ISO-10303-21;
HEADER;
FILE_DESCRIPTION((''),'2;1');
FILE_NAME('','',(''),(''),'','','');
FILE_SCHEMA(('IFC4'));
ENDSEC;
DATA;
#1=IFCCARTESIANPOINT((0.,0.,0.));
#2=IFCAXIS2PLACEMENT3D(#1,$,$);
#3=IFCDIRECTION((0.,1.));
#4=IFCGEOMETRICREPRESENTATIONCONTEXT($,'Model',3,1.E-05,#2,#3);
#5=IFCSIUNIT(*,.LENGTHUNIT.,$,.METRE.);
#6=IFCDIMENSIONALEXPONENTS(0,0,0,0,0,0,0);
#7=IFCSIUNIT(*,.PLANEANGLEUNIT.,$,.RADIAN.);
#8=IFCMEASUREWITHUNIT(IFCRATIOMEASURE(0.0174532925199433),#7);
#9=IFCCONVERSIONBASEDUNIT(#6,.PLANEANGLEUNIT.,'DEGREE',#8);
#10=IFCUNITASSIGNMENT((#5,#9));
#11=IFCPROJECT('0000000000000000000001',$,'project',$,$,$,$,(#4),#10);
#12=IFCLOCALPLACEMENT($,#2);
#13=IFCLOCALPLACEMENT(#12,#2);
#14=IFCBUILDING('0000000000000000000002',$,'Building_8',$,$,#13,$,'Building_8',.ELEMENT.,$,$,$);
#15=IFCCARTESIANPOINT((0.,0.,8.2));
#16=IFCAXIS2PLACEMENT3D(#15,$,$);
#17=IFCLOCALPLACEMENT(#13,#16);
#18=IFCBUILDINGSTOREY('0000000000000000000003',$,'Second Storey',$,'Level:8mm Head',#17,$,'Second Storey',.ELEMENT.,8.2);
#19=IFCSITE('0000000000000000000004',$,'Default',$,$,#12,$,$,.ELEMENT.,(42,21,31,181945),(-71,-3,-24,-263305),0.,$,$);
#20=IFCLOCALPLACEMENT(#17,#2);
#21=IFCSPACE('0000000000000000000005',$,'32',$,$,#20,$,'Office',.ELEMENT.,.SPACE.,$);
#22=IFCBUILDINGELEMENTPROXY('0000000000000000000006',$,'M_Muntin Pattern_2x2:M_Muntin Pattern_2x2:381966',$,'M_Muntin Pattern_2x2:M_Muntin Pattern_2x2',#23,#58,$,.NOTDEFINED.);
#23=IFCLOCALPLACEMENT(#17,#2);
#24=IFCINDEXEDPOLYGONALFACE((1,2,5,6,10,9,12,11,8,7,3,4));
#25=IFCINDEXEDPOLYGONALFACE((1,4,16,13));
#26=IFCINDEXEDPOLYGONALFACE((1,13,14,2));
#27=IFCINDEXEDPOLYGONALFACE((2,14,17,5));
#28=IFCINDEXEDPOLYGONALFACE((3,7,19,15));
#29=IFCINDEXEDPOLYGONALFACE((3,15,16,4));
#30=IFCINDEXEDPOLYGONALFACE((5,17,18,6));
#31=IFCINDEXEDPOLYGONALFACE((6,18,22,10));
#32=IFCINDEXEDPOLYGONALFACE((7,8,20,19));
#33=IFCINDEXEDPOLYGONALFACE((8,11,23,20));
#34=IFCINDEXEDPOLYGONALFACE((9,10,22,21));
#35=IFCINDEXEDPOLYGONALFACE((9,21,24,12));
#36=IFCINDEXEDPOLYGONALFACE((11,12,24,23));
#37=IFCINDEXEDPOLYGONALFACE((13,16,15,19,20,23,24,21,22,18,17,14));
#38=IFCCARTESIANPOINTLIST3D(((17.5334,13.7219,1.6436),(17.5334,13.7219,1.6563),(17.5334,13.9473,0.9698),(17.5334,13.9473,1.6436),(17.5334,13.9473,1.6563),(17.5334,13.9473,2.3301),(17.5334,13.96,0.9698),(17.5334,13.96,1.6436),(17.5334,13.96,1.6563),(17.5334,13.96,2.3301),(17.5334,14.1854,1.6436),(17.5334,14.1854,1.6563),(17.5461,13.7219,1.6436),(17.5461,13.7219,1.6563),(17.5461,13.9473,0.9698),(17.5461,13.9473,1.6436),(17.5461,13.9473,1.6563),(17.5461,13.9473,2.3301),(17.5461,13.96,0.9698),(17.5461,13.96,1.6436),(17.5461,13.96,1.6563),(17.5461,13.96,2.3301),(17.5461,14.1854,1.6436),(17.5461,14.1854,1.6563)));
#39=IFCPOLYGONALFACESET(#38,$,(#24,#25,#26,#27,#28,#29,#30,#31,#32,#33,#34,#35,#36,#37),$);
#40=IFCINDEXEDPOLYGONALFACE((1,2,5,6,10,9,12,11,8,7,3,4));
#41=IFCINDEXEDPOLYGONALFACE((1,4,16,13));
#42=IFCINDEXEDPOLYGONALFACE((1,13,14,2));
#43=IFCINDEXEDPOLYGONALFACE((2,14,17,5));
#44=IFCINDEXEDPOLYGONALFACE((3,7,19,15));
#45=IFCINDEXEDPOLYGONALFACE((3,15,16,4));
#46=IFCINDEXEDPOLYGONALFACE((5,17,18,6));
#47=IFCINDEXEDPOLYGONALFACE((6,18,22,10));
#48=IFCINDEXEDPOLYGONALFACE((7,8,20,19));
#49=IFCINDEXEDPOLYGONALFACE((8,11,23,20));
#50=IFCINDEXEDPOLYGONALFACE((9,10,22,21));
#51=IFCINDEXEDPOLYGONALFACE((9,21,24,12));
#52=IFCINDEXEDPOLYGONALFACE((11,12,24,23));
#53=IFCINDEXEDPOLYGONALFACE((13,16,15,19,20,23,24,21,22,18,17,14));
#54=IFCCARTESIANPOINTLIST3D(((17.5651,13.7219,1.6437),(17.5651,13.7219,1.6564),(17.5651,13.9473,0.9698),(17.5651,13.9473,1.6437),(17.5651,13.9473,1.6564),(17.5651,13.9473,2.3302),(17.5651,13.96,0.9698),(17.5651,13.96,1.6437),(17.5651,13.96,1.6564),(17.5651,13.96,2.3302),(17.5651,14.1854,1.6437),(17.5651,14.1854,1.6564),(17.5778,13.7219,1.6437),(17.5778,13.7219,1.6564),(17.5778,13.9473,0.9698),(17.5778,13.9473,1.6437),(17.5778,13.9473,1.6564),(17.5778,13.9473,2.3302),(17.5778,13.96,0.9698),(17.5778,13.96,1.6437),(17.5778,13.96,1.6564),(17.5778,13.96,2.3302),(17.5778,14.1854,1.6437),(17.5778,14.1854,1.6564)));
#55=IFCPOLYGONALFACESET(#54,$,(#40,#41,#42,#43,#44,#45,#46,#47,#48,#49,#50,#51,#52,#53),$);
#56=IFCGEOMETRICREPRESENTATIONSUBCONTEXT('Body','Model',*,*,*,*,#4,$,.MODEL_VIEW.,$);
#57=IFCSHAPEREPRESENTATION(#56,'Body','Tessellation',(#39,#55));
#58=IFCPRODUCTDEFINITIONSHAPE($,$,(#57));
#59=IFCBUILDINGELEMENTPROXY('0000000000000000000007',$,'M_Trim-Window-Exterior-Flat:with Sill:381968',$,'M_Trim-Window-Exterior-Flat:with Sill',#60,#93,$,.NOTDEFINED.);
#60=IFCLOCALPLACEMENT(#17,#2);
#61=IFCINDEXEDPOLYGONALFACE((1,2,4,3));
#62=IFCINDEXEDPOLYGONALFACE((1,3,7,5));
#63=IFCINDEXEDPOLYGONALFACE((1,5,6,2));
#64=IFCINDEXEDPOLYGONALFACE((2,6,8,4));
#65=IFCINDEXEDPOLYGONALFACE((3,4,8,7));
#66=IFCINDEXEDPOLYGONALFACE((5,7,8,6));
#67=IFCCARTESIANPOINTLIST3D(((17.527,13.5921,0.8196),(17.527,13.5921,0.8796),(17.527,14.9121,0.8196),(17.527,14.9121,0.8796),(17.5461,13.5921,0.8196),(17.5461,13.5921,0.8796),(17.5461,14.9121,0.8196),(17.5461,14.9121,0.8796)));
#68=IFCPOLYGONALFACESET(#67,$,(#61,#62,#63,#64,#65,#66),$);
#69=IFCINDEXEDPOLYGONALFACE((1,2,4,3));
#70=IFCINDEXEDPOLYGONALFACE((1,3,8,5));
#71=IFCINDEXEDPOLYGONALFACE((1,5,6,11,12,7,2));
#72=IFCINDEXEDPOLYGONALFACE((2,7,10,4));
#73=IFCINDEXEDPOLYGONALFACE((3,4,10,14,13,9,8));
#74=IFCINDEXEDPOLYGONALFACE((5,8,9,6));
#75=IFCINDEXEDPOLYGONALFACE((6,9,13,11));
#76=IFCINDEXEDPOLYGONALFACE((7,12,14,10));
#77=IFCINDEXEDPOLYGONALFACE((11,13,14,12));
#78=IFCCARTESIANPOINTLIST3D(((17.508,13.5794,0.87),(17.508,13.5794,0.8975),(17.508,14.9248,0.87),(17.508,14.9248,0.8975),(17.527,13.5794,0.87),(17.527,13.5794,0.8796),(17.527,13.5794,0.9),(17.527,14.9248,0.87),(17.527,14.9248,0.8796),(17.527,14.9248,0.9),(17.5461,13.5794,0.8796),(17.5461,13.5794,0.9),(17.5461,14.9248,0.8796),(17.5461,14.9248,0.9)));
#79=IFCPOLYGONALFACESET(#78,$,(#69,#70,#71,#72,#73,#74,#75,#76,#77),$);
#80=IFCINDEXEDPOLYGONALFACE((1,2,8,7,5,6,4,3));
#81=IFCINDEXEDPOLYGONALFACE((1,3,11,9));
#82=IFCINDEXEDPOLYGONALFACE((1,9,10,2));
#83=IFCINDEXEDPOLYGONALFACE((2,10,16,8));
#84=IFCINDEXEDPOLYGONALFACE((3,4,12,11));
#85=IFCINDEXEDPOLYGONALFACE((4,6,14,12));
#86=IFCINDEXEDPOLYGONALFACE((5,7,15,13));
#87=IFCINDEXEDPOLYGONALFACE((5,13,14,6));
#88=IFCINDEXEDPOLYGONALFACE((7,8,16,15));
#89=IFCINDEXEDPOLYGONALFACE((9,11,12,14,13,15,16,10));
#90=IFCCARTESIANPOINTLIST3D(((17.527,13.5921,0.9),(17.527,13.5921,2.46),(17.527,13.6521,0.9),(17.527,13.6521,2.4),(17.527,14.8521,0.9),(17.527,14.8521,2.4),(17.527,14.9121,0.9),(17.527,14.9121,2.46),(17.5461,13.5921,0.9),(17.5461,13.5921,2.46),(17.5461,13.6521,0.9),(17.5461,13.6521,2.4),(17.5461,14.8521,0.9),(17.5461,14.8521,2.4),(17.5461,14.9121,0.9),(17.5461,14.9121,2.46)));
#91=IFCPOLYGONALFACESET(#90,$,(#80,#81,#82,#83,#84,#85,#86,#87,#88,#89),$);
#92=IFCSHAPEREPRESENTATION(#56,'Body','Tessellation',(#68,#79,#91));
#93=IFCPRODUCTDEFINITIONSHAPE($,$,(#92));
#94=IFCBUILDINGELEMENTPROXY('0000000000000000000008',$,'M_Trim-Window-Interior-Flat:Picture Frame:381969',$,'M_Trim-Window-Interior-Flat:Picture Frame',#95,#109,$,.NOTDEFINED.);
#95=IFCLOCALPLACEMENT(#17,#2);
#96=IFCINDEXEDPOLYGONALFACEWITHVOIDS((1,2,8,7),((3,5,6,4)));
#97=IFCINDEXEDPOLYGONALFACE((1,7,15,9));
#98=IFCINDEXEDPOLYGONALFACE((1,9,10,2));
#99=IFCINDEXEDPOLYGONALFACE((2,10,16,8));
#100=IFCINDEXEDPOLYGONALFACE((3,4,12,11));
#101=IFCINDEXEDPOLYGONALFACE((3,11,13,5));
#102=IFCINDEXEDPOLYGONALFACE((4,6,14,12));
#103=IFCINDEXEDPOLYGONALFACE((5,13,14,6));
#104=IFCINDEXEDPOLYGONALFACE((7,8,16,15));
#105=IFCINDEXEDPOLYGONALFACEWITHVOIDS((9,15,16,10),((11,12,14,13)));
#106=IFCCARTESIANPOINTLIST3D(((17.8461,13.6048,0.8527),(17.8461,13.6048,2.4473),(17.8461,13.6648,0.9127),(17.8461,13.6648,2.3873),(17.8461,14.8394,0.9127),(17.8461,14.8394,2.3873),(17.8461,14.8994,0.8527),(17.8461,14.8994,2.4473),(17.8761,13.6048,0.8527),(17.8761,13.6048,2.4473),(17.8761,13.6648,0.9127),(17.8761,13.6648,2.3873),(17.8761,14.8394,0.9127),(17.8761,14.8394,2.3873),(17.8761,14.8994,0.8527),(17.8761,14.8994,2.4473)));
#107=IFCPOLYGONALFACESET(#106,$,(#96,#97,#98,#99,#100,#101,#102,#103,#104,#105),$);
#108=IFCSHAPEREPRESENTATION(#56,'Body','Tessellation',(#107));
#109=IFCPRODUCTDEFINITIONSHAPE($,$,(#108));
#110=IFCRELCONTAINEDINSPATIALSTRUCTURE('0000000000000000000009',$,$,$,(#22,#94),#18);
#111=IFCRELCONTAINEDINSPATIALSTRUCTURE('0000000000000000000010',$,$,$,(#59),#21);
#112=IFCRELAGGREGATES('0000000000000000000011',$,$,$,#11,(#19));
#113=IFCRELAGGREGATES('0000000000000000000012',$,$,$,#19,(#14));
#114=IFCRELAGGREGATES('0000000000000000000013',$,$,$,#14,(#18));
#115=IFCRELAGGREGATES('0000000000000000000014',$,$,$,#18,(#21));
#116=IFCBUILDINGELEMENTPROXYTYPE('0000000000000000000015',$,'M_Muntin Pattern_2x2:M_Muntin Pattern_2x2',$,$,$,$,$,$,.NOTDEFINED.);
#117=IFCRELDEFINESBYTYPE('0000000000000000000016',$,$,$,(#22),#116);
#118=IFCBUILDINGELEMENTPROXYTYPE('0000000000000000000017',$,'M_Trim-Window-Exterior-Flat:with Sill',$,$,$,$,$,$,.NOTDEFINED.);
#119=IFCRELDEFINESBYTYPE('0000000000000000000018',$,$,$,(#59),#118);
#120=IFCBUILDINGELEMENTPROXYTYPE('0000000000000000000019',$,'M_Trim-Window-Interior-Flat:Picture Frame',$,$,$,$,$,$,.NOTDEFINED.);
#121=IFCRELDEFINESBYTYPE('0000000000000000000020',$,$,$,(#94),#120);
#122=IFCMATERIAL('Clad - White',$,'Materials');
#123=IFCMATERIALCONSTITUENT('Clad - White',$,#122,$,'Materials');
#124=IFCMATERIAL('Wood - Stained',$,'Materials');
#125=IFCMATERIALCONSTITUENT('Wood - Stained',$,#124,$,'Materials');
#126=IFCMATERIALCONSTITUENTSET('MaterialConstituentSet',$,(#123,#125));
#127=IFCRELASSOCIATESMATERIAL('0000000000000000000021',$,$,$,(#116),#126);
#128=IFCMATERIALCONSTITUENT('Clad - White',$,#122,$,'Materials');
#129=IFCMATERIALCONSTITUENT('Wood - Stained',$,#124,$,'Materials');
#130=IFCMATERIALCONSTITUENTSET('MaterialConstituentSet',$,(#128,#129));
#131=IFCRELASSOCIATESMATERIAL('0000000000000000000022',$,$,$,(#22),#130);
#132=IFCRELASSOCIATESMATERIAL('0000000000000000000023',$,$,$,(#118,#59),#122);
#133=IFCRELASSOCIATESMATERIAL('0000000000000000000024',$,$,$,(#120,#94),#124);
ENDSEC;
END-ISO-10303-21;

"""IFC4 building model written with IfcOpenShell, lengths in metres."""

from ifc_helpers import new_model, entity, si_unit, converted_unit, direction, frame, origin, place, context, subcontext, project, spatial, indexed_curve, outline, extrude, source, transform, mapped, material, constituent, constituent_set, type_object, type_shapes, element, save


model = new_model("IFC4")

# Units and contexts
model_context = context("Model", 3, precision=1e-05, world=origin(), true_north=direction((0.0, 1.0)))
body_context = subcontext(model_context, "Body", "Model", "MODEL_VIEW")
ifc_project = project(units=[si_unit("LENGTHUNIT", "METRE"), converted_unit("PLANEANGLEUNIT", "DEGREE", entity("IfcRatioMeasure", 0.0174532925199433), si_unit("PLANEANGLEUNIT", "RADIAN"), dimensions=[0, 0, 0, 0, 0, 0, 0])], contexts=[model_context])

# Site, building, storey
site_placement = place(None, origin())
site = spatial("IfcSite", under=ifc_project, at=site_placement, Name="Default", CompositionType="ELEMENT", RefLatitude=(42, 21, 31, 181945), RefLongitude=(-71, -3, -24, -263305), RefElevation=0.0)
building_placement = place(site_placement, origin())
building = spatial("IfcBuilding", under=site, at=building_placement, Name="Building_8", LongName="Building_8", CompositionType="ELEMENT")
storey_placement = place(building_placement, frame((0.0, 0.0, 8.2)))
storey = spatial("IfcBuildingStorey", under=building, at=storey_placement, Name="Second Storey", ObjectType="Level:8mm Head", LongName="Second Storey", CompositionType="ELEMENT", Elevation=8.2)

# Shared definitions
ifc_material_1 = material(Name="Clad - White", Category="Materials")
ifc_material_2 = material(Name="Wood - Stained", Category="Materials")

# Building element proxy
ifc_constituent_1 = constituent(ifc_material_1, Name="Clad - White", Category="Materials")
ifc_constituent_2 = constituent(ifc_material_2, Name="Wood - Stained", Category="Materials")
ifc_constituent_set_1 = constituent_set(constituents=[ifc_constituent_1, ifc_constituent_2], Name="MaterialConstituentSet")
ifc_constituent_3 = constituent(ifc_material_1, Name="Clad - White", Category="Materials")
ifc_constituent_4 = constituent(ifc_material_2, Name="Wood - Stained", Category="Materials")
ifc_constituent_set_2 = constituent_set(constituents=[ifc_constituent_3, ifc_constituent_4], Name="MaterialConstituentSet")
building_element_proxy_type_1 = type_object("IfcBuildingElementProxyType", Name="M_Muntin Pattern_2x2:M_Muntin Pattern_2x2", PredefinedType="NOTDEFINED", material=ifc_constituent_set_2)
shared_shape_1 = source(origin(), body_context, "Body", "SweptSolid", [
    extrude(outline(indexed_curve([(0.0064, -0.0064), (0.6801, -0.0064), (0.6801, 0.0063), (0.0064, 0.0063), (0.0064, 0.2317), (-0.0063, 0.2317), (-0.0063, 0.0063), (-0.6802, 0.0063), (-0.6802, -0.0064), (-0.0063, -0.0064), (-0.0063, -0.2317), (0.0064, -0.2317), (0.0064, -0.0064)], self_intersect=False)), frame((0.0, 0.0095, 0.6801), z_axis=(0.0, 1.0, 0.0), x_axis=(0.0, 0.0, 1.0)), (0.0, 0.0, 1.0), 0.0127),
    extrude(outline(indexed_curve([(0.0064, -0.0064), (0.6802, -0.0064), (0.6802, 0.0063), (0.0064, 0.0063), (0.0064, 0.2317), (-0.0063, 0.2317), (-0.0063, 0.0063), (-0.6802, 0.0063), (-0.6802, -0.0064), (-0.0063, -0.0064), (-0.0063, -0.2317), (0.0064, -0.2317), (0.0064, -0.0064)], self_intersect=False)), frame((0.0, -0.0222, 0.6802), z_axis=(0.0, 1.0, 0.0), x_axis=(0.0, 0.0, 1.0)), (0.0, 0.0, 1.0), 0.0127),
])
type_shapes(building_element_proxy_type_1, [shared_shape_1])
proxy_1_placement = place(storey_placement, frame((17.5556, 13.9537, 0.9698), z_axis=(0.0, 0.0, 1.0), x_axis=(0.0, 1.0, 0.0)))
element("IfcBuildingElementProxy", 1, at=proxy_1_placement, inside=storey, type_object=building_element_proxy_type_1, material=ifc_constituent_set_1, Name="M_Muntin Pattern_2x2:M_Muntin Pattern_2x2:381966", ObjectType="M_Muntin Pattern_2x2:M_Muntin Pattern_2x2", PredefinedType="NOTDEFINED", context=body_context, shape_type="MappedRepresentation", body=[
    mapped(shared_shape_1, transform((0.0, 0.0, 0.0), scale=1.0)),
])

# Shared definitions
space_1_placement = place(storey_placement, origin())
space_1 = spatial("IfcSpace", under=storey, at=space_1_placement, Name="32", LongName="Office", CompositionType="ELEMENT", PredefinedType="SPACE")

# Building element proxies
building_element_proxy_type_2 = type_object("IfcBuildingElementProxyType", Name="M_Trim-Window-Exterior-Flat:with Sill", PredefinedType="NOTDEFINED", material=ifc_material_1)
shared_shape_2 = source(origin(), body_context, "Body", "SweptSolid", [
    extrude(outline(indexed_curve([(-0.66, -0.03), (0.66, -0.03), (0.66, 0.03), (-0.66, 0.03), (-0.66, -0.03)], self_intersect=False)), frame((0.0, -1.5504, 0.0), z_axis=(0.0, 0.0, 1.0), x_axis=(-1.0, 0.0, 0.0)), (0.0, 0.0, 1.0), 0.0191),
    extrude(outline(indexed_curve([(-0.019, -0.0152), (0.0, -0.0152), (0.0, -0.0057), (0.019, -0.0057), (0.019, 0.0148), (0.0, 0.0148), (-0.019, 0.0123), (-0.019, -0.0152)], self_intersect=False)), frame((-0.6727, -1.5148, 0.019), z_axis=(1.0, 0.0, 0.0), x_axis=(0.0, 0.0, -1.0)), (0.0, 0.0, 1.0), 1.3454),
    extrude(outline(indexed_curve([(-0.795, -0.66), (0.765, -0.66), (0.765, -0.6), (-0.735, -0.6), (-0.735, 0.6), (0.765, 0.6), (0.765, 0.66), (-0.795, 0.66), (-0.795, -0.66)], self_intersect=False)), frame((0.0, -0.735, 0.0), z_axis=(0.0, 0.0, 1.0), x_axis=(0.0, -1.0, 0.0)), (0.0, 0.0, 1.0), 0.0191),
])
type_shapes(building_element_proxy_type_2, [shared_shape_2])
proxy_2_placement = place(space_1_placement, frame((17.5461, 14.2521, 2.4), z_axis=(-1.0, 0.0, 0.0), x_axis=(0.0, -1.0, 0.0)))
element("IfcBuildingElementProxy", 2, at=proxy_2_placement, inside=space_1, type_object=building_element_proxy_type_2, material=ifc_material_1, Name="M_Trim-Window-Exterior-Flat:with Sill:381968", ObjectType="M_Trim-Window-Exterior-Flat:with Sill", PredefinedType="NOTDEFINED", context=body_context, shape_type="MappedRepresentation", body=[
    mapped(shared_shape_2, transform((0.0, 0.0, 0.0), scale=1.0)),
])
building_element_proxy_type_3 = type_object("IfcBuildingElementProxyType", Name="M_Trim-Window-Interior-Flat:Picture Frame", PredefinedType="NOTDEFINED", material=ifc_material_2)
shared_shape_3 = source(origin(), body_context, "Body", "SweptSolid", [
    extrude(outline(indexed_curve([(-0.6473, -0.7973), (0.6473, -0.7973), (0.6473, 0.7973), (-0.6473, 0.7973), (-0.6473, -0.7973)], self_intersect=False), holes=[indexed_curve([(-0.5873, -0.7373), (-0.5873, 0.7373), (0.5873, 0.7373), (0.5873, -0.7373), (-0.5873, -0.7373)], self_intersect=False)]), frame((0.0, -0.75, 0.0), z_axis=(0.0, 0.0, 1.0), x_axis=(-1.0, 0.0, 0.0)), (0.0, 0.0, 1.0), 0.03),
])
type_shapes(building_element_proxy_type_3, [shared_shape_3])
proxy_3_placement = place(storey_placement, frame((17.8461, 14.2521, 2.4), z_axis=(1.0, 0.0, 0.0), x_axis=(0.0, 1.0, 0.0)))
element("IfcBuildingElementProxy", 3, at=proxy_3_placement, inside=storey, type_object=building_element_proxy_type_3, material=ifc_material_2, Name="M_Trim-Window-Interior-Flat:Picture Frame:381969", ObjectType="M_Trim-Window-Interior-Flat:Picture Frame", PredefinedType="NOTDEFINED", context=body_context, shape_type="MappedRepresentation", body=[
    mapped(shared_shape_3, transform((0.0, 0.0, 0.0), scale=1.0)),
])

save(model, "model.ifc")
